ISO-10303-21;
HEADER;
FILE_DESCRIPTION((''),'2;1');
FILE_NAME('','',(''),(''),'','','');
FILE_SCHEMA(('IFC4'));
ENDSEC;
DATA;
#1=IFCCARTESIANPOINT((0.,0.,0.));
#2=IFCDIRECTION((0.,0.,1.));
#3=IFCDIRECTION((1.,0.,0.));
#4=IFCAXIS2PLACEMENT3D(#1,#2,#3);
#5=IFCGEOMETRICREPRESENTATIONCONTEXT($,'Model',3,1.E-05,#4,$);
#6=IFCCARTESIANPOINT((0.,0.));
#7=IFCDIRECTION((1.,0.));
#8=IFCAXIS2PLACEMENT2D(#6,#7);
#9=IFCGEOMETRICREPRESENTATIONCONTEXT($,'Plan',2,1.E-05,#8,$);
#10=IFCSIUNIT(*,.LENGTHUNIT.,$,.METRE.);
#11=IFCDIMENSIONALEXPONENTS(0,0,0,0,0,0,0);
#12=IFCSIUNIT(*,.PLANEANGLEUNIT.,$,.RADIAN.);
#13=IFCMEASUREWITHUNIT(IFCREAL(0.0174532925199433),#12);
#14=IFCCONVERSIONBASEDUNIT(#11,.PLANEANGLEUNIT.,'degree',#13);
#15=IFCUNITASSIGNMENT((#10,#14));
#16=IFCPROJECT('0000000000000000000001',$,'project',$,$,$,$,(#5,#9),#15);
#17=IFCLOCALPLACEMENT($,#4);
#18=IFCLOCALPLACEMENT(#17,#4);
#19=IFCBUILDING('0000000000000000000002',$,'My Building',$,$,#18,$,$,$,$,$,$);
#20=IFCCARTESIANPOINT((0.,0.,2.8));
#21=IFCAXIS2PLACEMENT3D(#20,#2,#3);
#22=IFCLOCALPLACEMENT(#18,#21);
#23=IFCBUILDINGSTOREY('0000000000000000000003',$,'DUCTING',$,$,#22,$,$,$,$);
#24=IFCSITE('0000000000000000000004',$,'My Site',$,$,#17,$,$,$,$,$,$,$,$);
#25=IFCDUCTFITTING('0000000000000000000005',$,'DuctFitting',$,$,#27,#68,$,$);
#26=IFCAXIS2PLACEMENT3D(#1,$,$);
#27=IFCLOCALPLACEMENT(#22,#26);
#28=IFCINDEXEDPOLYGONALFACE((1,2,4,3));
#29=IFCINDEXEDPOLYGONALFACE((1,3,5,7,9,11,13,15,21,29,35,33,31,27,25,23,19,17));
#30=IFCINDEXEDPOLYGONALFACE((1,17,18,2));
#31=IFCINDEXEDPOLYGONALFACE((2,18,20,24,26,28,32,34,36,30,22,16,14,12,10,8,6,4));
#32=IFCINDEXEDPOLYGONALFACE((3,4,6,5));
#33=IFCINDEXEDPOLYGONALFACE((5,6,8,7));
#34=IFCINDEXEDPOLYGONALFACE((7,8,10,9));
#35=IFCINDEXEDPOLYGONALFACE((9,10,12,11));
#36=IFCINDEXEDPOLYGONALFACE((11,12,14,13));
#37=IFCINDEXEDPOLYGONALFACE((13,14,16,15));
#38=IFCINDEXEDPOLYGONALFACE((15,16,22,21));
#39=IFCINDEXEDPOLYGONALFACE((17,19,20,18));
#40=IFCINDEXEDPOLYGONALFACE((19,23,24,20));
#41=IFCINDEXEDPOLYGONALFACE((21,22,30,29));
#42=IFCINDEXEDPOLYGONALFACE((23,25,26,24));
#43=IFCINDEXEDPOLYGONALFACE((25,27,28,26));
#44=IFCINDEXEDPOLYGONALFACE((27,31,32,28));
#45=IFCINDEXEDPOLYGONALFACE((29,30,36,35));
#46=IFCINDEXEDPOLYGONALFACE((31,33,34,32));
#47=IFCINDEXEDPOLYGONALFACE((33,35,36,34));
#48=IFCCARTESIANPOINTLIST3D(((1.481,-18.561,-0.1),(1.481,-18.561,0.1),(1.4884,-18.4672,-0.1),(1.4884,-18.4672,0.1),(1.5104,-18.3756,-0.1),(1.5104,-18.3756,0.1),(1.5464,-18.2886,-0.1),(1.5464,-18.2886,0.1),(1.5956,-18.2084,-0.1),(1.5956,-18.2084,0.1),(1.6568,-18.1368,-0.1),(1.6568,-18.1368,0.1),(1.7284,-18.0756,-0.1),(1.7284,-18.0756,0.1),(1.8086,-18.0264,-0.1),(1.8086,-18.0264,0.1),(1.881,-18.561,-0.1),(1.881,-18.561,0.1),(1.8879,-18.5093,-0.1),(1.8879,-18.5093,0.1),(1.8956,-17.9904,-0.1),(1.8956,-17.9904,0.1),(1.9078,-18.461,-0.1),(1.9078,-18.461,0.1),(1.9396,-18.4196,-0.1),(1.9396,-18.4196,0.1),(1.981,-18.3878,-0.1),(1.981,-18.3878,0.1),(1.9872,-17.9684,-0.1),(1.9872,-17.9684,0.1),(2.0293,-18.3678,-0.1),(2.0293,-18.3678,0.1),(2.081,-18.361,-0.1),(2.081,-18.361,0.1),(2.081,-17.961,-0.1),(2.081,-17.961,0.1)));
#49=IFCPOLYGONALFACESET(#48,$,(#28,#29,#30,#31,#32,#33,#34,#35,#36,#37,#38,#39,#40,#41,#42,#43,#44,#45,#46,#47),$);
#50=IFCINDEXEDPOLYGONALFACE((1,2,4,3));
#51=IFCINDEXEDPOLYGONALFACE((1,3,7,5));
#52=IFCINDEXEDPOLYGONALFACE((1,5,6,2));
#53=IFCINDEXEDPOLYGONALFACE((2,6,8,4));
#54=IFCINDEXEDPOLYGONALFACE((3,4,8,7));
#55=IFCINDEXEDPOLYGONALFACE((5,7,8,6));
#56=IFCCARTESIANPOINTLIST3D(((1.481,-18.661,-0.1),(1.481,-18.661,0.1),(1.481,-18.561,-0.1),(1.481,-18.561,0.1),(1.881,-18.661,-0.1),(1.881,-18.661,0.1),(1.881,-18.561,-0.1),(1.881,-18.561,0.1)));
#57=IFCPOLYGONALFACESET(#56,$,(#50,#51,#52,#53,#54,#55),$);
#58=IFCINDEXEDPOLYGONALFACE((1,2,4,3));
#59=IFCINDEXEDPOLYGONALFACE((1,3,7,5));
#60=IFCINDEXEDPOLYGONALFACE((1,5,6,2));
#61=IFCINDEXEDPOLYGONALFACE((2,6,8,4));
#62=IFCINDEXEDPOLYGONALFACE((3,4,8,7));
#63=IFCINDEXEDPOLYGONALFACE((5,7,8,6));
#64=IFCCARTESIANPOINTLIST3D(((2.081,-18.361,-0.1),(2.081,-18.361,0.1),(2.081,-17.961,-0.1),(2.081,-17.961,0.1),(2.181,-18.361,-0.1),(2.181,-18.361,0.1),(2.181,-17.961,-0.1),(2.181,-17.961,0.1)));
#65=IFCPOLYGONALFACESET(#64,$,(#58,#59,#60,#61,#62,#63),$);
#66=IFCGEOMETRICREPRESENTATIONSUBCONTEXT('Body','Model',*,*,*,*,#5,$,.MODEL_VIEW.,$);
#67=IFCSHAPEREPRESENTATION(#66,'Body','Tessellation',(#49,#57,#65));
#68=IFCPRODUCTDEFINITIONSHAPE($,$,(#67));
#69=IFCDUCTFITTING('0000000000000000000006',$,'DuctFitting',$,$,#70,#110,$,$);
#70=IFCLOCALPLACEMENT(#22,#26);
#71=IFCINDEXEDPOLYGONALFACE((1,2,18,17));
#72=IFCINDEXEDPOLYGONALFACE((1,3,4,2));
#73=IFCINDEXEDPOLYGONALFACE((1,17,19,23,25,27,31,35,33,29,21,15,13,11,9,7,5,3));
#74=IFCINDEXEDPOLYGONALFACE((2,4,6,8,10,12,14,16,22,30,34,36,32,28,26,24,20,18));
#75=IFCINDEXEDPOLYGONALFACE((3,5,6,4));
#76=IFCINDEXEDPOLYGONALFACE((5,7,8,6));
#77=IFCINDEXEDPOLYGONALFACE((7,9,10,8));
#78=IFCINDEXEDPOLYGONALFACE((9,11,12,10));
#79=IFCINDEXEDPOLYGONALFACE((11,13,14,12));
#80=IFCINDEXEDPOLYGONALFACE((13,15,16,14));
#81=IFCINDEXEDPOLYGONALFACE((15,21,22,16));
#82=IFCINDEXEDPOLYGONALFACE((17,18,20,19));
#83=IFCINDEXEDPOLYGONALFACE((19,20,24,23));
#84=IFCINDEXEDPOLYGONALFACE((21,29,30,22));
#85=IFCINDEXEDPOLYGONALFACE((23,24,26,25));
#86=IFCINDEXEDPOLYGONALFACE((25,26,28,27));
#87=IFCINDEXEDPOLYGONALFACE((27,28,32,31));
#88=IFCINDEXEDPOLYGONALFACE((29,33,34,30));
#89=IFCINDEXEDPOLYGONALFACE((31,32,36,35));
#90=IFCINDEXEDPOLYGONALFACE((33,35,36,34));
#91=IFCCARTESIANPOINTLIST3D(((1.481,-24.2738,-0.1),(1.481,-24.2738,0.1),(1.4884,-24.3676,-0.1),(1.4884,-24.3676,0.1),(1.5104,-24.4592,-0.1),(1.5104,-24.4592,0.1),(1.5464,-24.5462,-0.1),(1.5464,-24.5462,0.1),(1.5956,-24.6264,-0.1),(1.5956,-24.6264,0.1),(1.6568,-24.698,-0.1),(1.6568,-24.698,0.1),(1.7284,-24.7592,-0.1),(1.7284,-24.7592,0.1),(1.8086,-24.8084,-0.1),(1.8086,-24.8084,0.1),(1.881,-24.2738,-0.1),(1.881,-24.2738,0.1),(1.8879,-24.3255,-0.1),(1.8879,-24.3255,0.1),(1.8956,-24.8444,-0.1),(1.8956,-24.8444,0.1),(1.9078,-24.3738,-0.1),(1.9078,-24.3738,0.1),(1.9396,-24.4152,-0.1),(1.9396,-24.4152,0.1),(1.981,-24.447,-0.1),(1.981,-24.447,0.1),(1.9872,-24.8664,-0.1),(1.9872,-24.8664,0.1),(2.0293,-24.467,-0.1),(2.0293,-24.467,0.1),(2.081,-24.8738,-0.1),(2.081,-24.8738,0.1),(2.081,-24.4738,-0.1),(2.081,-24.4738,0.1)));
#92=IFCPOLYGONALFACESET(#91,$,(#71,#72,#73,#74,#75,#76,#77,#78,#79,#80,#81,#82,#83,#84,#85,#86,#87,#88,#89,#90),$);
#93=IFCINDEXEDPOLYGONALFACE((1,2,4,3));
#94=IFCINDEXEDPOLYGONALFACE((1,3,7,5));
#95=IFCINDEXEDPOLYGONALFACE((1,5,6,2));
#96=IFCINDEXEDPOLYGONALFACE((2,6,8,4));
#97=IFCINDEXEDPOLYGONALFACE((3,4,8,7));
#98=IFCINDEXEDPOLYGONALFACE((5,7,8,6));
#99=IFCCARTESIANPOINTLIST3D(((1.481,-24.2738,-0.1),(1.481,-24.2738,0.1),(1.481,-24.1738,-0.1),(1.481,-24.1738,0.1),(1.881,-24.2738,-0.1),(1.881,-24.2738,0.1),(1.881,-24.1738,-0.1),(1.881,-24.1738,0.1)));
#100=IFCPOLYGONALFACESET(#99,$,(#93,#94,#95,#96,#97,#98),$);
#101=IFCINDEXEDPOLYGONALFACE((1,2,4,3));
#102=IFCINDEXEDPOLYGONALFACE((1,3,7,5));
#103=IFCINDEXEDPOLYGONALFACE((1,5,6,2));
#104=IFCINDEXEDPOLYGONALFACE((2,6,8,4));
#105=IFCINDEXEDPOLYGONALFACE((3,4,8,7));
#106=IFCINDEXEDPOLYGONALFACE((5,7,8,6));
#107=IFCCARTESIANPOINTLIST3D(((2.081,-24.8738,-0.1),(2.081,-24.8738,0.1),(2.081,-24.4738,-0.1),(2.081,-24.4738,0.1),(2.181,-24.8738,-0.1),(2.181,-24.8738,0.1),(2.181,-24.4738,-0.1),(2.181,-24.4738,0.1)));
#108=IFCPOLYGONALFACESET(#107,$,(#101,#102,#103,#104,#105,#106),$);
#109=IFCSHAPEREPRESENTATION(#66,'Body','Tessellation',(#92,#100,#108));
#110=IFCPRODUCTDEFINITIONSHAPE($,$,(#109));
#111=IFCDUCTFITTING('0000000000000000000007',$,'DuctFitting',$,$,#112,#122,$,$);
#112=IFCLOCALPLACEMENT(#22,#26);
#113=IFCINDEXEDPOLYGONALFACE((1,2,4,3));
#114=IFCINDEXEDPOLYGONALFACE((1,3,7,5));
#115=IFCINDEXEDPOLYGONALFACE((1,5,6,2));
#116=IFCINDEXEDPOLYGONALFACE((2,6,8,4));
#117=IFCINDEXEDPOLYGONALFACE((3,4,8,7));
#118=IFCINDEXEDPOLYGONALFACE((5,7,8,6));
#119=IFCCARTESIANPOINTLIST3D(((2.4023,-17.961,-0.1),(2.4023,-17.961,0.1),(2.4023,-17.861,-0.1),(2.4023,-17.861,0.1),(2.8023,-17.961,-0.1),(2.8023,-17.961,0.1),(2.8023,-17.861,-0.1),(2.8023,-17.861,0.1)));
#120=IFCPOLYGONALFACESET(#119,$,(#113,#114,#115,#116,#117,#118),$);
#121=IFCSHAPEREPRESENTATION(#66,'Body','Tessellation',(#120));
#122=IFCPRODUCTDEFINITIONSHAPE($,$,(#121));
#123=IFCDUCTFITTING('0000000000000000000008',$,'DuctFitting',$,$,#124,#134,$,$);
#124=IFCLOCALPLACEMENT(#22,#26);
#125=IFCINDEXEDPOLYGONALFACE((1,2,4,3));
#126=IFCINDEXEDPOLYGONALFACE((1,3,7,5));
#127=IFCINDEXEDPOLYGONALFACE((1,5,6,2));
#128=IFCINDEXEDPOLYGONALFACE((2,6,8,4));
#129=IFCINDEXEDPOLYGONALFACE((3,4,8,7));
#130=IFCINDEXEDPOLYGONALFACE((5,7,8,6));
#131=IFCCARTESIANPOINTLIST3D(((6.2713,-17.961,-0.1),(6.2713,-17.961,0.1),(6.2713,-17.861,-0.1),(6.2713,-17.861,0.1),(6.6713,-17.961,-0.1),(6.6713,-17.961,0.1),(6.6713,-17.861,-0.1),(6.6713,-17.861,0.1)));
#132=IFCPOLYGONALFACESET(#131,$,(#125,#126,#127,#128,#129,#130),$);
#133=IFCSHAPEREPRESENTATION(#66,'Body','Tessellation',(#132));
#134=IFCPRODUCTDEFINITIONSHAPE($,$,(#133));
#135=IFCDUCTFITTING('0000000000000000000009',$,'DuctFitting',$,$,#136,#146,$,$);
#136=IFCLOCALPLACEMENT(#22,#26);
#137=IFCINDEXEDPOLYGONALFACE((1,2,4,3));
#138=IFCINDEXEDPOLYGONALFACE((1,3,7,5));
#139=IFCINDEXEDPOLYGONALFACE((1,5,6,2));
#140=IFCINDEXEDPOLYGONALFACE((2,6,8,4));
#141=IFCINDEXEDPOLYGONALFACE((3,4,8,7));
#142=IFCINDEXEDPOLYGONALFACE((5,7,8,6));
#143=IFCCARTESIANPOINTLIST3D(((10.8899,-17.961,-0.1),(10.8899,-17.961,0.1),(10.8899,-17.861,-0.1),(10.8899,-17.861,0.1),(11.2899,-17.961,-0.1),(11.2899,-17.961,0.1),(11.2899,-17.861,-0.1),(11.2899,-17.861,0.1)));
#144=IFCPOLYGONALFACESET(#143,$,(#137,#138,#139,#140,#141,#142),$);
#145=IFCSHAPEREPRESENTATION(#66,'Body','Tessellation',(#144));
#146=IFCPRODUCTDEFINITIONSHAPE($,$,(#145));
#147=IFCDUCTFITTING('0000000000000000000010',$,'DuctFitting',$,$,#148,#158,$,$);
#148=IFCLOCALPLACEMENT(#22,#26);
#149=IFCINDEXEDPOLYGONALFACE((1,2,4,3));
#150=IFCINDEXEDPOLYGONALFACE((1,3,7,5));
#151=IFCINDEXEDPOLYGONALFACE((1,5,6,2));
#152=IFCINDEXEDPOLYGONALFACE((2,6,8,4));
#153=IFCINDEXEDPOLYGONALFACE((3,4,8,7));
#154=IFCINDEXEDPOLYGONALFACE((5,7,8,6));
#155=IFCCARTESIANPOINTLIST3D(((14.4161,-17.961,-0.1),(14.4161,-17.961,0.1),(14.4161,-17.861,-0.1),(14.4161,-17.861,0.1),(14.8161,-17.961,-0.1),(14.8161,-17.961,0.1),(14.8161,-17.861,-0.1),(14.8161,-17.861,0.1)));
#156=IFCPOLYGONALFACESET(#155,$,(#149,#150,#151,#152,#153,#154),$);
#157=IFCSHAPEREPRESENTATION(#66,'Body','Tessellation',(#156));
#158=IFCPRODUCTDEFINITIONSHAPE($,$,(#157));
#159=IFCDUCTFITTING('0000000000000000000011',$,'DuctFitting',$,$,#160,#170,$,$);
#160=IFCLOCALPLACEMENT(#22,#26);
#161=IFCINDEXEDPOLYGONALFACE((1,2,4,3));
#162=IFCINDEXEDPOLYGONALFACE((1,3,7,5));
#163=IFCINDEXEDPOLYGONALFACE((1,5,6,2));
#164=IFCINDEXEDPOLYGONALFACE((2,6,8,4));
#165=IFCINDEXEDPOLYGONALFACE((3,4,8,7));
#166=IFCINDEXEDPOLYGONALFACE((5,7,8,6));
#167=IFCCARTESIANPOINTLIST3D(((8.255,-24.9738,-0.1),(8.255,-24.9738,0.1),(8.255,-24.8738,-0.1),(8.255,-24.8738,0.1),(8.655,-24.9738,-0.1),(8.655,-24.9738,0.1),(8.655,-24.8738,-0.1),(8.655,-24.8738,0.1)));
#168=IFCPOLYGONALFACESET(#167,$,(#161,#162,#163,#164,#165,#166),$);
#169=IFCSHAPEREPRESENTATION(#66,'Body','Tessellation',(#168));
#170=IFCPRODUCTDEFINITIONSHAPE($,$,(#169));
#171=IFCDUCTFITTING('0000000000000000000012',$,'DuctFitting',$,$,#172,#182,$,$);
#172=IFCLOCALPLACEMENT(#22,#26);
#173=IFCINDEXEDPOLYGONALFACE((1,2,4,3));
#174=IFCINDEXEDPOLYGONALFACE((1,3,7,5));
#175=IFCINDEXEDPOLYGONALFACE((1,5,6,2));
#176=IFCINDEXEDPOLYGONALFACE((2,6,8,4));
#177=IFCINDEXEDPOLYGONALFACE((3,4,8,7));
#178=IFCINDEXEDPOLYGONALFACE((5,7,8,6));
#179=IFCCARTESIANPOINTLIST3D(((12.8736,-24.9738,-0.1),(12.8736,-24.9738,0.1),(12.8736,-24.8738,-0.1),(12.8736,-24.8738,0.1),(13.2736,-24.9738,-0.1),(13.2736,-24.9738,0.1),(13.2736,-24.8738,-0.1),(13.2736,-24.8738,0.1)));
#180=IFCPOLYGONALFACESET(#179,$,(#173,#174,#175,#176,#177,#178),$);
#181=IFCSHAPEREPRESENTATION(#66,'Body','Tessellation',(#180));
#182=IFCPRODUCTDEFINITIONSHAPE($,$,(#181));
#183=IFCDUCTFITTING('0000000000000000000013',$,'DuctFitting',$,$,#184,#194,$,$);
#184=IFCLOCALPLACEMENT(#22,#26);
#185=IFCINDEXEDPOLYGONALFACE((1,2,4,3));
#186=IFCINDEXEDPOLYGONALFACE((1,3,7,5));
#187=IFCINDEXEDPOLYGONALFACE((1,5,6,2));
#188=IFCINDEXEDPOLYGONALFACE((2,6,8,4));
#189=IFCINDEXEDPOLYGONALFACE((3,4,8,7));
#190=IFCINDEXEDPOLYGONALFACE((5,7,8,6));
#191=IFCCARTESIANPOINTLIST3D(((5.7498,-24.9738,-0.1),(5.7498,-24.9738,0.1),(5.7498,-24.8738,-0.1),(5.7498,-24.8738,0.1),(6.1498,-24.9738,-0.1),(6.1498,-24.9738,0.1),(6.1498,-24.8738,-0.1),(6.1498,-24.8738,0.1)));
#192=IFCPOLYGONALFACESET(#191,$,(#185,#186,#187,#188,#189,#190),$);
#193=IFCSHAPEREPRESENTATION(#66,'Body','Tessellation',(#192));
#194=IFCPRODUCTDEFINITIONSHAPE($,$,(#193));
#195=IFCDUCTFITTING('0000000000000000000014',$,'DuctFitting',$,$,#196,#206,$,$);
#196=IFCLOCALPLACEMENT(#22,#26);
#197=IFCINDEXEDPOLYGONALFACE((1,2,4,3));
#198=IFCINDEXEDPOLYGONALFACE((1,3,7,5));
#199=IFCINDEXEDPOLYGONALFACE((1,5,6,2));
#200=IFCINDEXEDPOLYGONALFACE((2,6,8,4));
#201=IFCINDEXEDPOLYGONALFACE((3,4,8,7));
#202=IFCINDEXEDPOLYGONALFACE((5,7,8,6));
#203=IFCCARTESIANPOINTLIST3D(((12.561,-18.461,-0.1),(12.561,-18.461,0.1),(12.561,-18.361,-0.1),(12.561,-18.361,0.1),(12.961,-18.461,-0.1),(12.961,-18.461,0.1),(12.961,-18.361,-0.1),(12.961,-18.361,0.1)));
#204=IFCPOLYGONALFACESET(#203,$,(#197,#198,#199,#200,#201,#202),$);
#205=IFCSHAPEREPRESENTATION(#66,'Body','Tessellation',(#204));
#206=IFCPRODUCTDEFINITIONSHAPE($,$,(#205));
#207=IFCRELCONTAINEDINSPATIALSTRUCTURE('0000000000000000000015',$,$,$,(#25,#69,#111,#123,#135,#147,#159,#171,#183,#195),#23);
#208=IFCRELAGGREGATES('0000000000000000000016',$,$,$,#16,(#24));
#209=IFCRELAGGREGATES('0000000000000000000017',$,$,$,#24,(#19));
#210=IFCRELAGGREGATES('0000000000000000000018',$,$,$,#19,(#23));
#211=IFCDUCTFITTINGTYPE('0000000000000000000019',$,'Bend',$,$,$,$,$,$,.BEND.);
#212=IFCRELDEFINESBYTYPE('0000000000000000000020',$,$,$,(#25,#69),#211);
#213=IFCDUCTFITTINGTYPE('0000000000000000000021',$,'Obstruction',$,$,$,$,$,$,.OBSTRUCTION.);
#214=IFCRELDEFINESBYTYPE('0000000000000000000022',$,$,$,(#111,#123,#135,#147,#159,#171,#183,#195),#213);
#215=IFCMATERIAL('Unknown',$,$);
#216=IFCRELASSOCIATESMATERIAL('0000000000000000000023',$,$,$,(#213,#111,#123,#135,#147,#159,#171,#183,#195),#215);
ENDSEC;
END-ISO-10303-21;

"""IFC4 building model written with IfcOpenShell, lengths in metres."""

from ifc_helpers import new_model, entity, si_unit, converted_unit, frame, origin_with_axes, origin_2d_with_axis, place, context, subcontext, project, spatial, line, arc, indexed_curve, rectangle, outline, extrude, source, transform, mapped, material, material_profile, profile_set, profile_usage, type_object, type_shapes, element, save


model = new_model("IFC4")

# Units and contexts
model_context = context("Model", 3, precision=1e-05, world=origin_with_axes())
plan_context = context("Plan", 2, precision=1e-05, world=origin_2d_with_axis())
body_context = subcontext(model_context, "Body", "Model", "MODEL_VIEW")
ifc_project = project(units=[si_unit("LENGTHUNIT", "METRE"), converted_unit("PLANEANGLEUNIT", "degree", entity("IfcReal", 0.0174532925199433), si_unit("PLANEANGLEUNIT", "RADIAN"), dimensions=[0, 0, 0, 0, 0, 0, 0])], contexts=[model_context, plan_context])

# Site, building, storey
site_placement = place(None, origin_with_axes())
site = spatial("IfcSite", under=ifc_project, at=site_placement, Name="My Site")
building_placement = place(site_placement, origin_with_axes())
building = spatial("IfcBuilding", under=site, at=building_placement, Name="My Building")
storey_placement = place(building_placement, frame((0.0, 0.0, 2.8), z_axis=(0.0, 0.0, 1.0), x_axis=(1.0, 0.0, 0.0)))
storey = spatial("IfcBuildingStorey", under=building, at=storey_placement, Name="DUCTING")

# Shared definitions
ifc_material = material(Name="Unknown")

# Duct fittings
duct_fitting_type_1 = type_object("IfcDuctFittingType", Name="Bend", PredefinedType="BEND")
shared_shape = source(origin_with_axes(), body_context, "Body", "SweptSolid", [
    extrude(outline(indexed_curve([(-0.2, 0.0), (-0.2586, -0.1414), (-0.4, -0.2), (-0.4, -0.6), (0.0243, -0.4243), (0.2, 0.0)], segments=[arc(1, 2, 3), line(3, 4), arc(4, 5, 6), line(6, 1)])), frame((0.0, -0.1, -0.1), z_axis=(0.0, -1.0, 0.0), x_axis=(1.0, 0.0, 0.0)), (0.0, 0.0, -1.0), 0.2),
    extrude(rectangle(XDim=0.4, YDim=0.2), origin_with_axes(), (0.0, 0.0, -1.0), 0.1),
    extrude(rectangle(XDim=0.4, YDim=0.2), frame((-0.4, 0.0, -0.5), z_axis=(-1.0, 0.0, 0.0), x_axis=(0.0, 0.0, -1.0)), (0.0, 0.0, 1.0), 0.1),
])
type_shapes(duct_fitting_type_1, [shared_shape])
for number, where, z_axis, x_axis, name in (
    (1, (1.681, -18.661, 0.0), (0.0, -1.0, 0.0), (-1.0, 0.0, 0.0), "DuctFitting"),
    (2, (1.681, -24.1738, 0.0), (0.0, 1.0, 0.0), (-1.0, 0.0, 0.0), "DuctFitting"),
):
    element("IfcDuctFitting", number, at=place(storey_placement, frame(where, z_axis=z_axis, x_axis=x_axis)), inside=storey, type_object=duct_fitting_type_1, Name=name, context=body_context, shape_type="MappedRepresentation", body=[
        mapped(shared_shape, transform((0.0, 0.0, 0.0), x_axis=(1.0, 0.0, 0.0), y_axis=(0.0, 1.0, 0.0), z_axis=(0.0, 0.0, 1.0), scale=1.0)),
    ])
ifc_material_profile_1 = material_profile(ifc_material, rectangle(XDim=0.4, YDim=0.2))
ifc_profile_set_1 = profile_set([ifc_material_profile_1])
ifc_profile_usage_1 = profile_usage(ifc_profile_set_1, cardinal=5)
duct_fitting_type_2 = type_object("IfcDuctFittingType", Name="Obstruction", PredefinedType="OBSTRUCTION", material=ifc_profile_set_1)
duct_fitting_1_placement = place(storey_placement, frame((2.6023, -17.961, 0.0), z_axis=(0.0, 1.0, 0.0), x_axis=(-1.0, 0.0, 0.0)))
element("IfcDuctFitting", 3, at=duct_fitting_1_placement, inside=storey, type_object=duct_fitting_type_2, material=ifc_profile_usage_1, Name="DuctFitting", context=body_context, shape_type="SweptSolid", body=[
    extrude(rectangle(XDim=0.4, YDim=0.2), origin_with_axes(), (0.0, 0.0, 1.0), 0.1),
])
ifc_profile_usage_2 = profile_usage(ifc_profile_set_1, cardinal=5)
duct_fitting_2_placement = place(storey_placement, frame((6.4713, -17.961, 0.0), z_axis=(0.0, 1.0, 0.0), x_axis=(-1.0, 0.0, 0.0)))
element("IfcDuctFitting", 4, at=duct_fitting_2_placement, inside=storey, type_object=duct_fitting_type_2, material=ifc_profile_usage_2, Name="DuctFitting", context=body_context, shape_type="SweptSolid", body=[
    extrude(rectangle(XDim=0.4, YDim=0.2), origin_with_axes(), (0.0, 0.0, 1.0), 0.1),
])
ifc_profile_usage_3 = profile_usage(ifc_profile_set_1, cardinal=5)
duct_fitting_3_placement = place(storey_placement, frame((11.0899, -17.961, 0.0), z_axis=(0.0, 1.0, 0.0), x_axis=(-1.0, 0.0, 0.0)))
element("IfcDuctFitting", 5, at=duct_fitting_3_placement, inside=storey, type_object=duct_fitting_type_2, material=ifc_profile_usage_3, Name="DuctFitting", context=body_context, shape_type="SweptSolid", body=[
    extrude(rectangle(XDim=0.4, YDim=0.2), origin_with_axes(), (0.0, 0.0, 1.0), 0.1),
])
ifc_profile_usage_4 = profile_usage(ifc_profile_set_1, cardinal=5)
duct_fitting_4_placement = place(storey_placement, frame((14.6161, -17.961, 0.0), z_axis=(0.0, 1.0, 0.0), x_axis=(-1.0, 0.0, 0.0)))
element("IfcDuctFitting", 6, at=duct_fitting_4_placement, inside=storey, type_object=duct_fitting_type_2, material=ifc_profile_usage_4, Name="DuctFitting", context=body_context, shape_type="SweptSolid", body=[
    extrude(rectangle(XDim=0.4, YDim=0.2), origin_with_axes(), (0.0, 0.0, 1.0), 0.1),
])
ifc_profile_usage_5 = profile_usage(ifc_profile_set_1, cardinal=5)
duct_fitting_5_placement = place(storey_placement, frame((8.455, -24.8738, 0.0), z_axis=(0.0, -1.0, 0.0), x_axis=(1.0, 0.0, 0.0)))
element("IfcDuctFitting", 7, at=duct_fitting_5_placement, inside=storey, type_object=duct_fitting_type_2, material=ifc_profile_usage_5, Name="DuctFitting", context=body_context, shape_type="SweptSolid", body=[
    extrude(rectangle(XDim=0.4, YDim=0.2), origin_with_axes(), (0.0, 0.0, 1.0), 0.1),
])
ifc_profile_usage_6 = profile_usage(ifc_profile_set_1, cardinal=5)
duct_fitting_6_placement = place(storey_placement, frame((13.0736, -24.8738, 0.0), z_axis=(0.0, -1.0, 0.0), x_axis=(1.0, 0.0, 0.0)))
element("IfcDuctFitting", 8, at=duct_fitting_6_placement, inside=storey, type_object=duct_fitting_type_2, material=ifc_profile_usage_6, Name="DuctFitting", context=body_context, shape_type="SweptSolid", body=[
    extrude(rectangle(XDim=0.4, YDim=0.2), origin_with_axes(), (0.0, 0.0, 1.0), 0.1),
])
ifc_profile_usage_7 = profile_usage(ifc_profile_set_1, cardinal=5)
duct_fitting_7_placement = place(storey_placement, frame((5.9498, -24.8738, 0.0), z_axis=(0.0, -1.0, 0.0), x_axis=(1.0, 0.0, 0.0)))
element("IfcDuctFitting", 9, at=duct_fitting_7_placement, inside=storey, type_object=duct_fitting_type_2, material=ifc_profile_usage_7, Name="DuctFitting", context=body_context, shape_type="SweptSolid", body=[
    extrude(rectangle(XDim=0.4, YDim=0.2), origin_with_axes(), (0.0, 0.0, 1.0), 0.1),
])
ifc_profile_usage_8 = profile_usage(ifc_profile_set_1, cardinal=5)
duct_fitting_8_placement = place(storey_placement, frame((12.761, -18.361, 0.0), z_axis=(0.0, -1.0, 0.0), x_axis=(1.0, 0.0, 0.0)))
element("IfcDuctFitting", 10, at=duct_fitting_8_placement, inside=storey, type_object=duct_fitting_type_2, material=ifc_profile_usage_8, Name="DuctFitting", context=body_context, shape_type="SweptSolid", body=[
    extrude(rectangle(XDim=0.4, YDim=0.2), origin_with_axes(), (0.0, 0.0, 1.0), 0.1),
])

save(model, "model.ifc")
